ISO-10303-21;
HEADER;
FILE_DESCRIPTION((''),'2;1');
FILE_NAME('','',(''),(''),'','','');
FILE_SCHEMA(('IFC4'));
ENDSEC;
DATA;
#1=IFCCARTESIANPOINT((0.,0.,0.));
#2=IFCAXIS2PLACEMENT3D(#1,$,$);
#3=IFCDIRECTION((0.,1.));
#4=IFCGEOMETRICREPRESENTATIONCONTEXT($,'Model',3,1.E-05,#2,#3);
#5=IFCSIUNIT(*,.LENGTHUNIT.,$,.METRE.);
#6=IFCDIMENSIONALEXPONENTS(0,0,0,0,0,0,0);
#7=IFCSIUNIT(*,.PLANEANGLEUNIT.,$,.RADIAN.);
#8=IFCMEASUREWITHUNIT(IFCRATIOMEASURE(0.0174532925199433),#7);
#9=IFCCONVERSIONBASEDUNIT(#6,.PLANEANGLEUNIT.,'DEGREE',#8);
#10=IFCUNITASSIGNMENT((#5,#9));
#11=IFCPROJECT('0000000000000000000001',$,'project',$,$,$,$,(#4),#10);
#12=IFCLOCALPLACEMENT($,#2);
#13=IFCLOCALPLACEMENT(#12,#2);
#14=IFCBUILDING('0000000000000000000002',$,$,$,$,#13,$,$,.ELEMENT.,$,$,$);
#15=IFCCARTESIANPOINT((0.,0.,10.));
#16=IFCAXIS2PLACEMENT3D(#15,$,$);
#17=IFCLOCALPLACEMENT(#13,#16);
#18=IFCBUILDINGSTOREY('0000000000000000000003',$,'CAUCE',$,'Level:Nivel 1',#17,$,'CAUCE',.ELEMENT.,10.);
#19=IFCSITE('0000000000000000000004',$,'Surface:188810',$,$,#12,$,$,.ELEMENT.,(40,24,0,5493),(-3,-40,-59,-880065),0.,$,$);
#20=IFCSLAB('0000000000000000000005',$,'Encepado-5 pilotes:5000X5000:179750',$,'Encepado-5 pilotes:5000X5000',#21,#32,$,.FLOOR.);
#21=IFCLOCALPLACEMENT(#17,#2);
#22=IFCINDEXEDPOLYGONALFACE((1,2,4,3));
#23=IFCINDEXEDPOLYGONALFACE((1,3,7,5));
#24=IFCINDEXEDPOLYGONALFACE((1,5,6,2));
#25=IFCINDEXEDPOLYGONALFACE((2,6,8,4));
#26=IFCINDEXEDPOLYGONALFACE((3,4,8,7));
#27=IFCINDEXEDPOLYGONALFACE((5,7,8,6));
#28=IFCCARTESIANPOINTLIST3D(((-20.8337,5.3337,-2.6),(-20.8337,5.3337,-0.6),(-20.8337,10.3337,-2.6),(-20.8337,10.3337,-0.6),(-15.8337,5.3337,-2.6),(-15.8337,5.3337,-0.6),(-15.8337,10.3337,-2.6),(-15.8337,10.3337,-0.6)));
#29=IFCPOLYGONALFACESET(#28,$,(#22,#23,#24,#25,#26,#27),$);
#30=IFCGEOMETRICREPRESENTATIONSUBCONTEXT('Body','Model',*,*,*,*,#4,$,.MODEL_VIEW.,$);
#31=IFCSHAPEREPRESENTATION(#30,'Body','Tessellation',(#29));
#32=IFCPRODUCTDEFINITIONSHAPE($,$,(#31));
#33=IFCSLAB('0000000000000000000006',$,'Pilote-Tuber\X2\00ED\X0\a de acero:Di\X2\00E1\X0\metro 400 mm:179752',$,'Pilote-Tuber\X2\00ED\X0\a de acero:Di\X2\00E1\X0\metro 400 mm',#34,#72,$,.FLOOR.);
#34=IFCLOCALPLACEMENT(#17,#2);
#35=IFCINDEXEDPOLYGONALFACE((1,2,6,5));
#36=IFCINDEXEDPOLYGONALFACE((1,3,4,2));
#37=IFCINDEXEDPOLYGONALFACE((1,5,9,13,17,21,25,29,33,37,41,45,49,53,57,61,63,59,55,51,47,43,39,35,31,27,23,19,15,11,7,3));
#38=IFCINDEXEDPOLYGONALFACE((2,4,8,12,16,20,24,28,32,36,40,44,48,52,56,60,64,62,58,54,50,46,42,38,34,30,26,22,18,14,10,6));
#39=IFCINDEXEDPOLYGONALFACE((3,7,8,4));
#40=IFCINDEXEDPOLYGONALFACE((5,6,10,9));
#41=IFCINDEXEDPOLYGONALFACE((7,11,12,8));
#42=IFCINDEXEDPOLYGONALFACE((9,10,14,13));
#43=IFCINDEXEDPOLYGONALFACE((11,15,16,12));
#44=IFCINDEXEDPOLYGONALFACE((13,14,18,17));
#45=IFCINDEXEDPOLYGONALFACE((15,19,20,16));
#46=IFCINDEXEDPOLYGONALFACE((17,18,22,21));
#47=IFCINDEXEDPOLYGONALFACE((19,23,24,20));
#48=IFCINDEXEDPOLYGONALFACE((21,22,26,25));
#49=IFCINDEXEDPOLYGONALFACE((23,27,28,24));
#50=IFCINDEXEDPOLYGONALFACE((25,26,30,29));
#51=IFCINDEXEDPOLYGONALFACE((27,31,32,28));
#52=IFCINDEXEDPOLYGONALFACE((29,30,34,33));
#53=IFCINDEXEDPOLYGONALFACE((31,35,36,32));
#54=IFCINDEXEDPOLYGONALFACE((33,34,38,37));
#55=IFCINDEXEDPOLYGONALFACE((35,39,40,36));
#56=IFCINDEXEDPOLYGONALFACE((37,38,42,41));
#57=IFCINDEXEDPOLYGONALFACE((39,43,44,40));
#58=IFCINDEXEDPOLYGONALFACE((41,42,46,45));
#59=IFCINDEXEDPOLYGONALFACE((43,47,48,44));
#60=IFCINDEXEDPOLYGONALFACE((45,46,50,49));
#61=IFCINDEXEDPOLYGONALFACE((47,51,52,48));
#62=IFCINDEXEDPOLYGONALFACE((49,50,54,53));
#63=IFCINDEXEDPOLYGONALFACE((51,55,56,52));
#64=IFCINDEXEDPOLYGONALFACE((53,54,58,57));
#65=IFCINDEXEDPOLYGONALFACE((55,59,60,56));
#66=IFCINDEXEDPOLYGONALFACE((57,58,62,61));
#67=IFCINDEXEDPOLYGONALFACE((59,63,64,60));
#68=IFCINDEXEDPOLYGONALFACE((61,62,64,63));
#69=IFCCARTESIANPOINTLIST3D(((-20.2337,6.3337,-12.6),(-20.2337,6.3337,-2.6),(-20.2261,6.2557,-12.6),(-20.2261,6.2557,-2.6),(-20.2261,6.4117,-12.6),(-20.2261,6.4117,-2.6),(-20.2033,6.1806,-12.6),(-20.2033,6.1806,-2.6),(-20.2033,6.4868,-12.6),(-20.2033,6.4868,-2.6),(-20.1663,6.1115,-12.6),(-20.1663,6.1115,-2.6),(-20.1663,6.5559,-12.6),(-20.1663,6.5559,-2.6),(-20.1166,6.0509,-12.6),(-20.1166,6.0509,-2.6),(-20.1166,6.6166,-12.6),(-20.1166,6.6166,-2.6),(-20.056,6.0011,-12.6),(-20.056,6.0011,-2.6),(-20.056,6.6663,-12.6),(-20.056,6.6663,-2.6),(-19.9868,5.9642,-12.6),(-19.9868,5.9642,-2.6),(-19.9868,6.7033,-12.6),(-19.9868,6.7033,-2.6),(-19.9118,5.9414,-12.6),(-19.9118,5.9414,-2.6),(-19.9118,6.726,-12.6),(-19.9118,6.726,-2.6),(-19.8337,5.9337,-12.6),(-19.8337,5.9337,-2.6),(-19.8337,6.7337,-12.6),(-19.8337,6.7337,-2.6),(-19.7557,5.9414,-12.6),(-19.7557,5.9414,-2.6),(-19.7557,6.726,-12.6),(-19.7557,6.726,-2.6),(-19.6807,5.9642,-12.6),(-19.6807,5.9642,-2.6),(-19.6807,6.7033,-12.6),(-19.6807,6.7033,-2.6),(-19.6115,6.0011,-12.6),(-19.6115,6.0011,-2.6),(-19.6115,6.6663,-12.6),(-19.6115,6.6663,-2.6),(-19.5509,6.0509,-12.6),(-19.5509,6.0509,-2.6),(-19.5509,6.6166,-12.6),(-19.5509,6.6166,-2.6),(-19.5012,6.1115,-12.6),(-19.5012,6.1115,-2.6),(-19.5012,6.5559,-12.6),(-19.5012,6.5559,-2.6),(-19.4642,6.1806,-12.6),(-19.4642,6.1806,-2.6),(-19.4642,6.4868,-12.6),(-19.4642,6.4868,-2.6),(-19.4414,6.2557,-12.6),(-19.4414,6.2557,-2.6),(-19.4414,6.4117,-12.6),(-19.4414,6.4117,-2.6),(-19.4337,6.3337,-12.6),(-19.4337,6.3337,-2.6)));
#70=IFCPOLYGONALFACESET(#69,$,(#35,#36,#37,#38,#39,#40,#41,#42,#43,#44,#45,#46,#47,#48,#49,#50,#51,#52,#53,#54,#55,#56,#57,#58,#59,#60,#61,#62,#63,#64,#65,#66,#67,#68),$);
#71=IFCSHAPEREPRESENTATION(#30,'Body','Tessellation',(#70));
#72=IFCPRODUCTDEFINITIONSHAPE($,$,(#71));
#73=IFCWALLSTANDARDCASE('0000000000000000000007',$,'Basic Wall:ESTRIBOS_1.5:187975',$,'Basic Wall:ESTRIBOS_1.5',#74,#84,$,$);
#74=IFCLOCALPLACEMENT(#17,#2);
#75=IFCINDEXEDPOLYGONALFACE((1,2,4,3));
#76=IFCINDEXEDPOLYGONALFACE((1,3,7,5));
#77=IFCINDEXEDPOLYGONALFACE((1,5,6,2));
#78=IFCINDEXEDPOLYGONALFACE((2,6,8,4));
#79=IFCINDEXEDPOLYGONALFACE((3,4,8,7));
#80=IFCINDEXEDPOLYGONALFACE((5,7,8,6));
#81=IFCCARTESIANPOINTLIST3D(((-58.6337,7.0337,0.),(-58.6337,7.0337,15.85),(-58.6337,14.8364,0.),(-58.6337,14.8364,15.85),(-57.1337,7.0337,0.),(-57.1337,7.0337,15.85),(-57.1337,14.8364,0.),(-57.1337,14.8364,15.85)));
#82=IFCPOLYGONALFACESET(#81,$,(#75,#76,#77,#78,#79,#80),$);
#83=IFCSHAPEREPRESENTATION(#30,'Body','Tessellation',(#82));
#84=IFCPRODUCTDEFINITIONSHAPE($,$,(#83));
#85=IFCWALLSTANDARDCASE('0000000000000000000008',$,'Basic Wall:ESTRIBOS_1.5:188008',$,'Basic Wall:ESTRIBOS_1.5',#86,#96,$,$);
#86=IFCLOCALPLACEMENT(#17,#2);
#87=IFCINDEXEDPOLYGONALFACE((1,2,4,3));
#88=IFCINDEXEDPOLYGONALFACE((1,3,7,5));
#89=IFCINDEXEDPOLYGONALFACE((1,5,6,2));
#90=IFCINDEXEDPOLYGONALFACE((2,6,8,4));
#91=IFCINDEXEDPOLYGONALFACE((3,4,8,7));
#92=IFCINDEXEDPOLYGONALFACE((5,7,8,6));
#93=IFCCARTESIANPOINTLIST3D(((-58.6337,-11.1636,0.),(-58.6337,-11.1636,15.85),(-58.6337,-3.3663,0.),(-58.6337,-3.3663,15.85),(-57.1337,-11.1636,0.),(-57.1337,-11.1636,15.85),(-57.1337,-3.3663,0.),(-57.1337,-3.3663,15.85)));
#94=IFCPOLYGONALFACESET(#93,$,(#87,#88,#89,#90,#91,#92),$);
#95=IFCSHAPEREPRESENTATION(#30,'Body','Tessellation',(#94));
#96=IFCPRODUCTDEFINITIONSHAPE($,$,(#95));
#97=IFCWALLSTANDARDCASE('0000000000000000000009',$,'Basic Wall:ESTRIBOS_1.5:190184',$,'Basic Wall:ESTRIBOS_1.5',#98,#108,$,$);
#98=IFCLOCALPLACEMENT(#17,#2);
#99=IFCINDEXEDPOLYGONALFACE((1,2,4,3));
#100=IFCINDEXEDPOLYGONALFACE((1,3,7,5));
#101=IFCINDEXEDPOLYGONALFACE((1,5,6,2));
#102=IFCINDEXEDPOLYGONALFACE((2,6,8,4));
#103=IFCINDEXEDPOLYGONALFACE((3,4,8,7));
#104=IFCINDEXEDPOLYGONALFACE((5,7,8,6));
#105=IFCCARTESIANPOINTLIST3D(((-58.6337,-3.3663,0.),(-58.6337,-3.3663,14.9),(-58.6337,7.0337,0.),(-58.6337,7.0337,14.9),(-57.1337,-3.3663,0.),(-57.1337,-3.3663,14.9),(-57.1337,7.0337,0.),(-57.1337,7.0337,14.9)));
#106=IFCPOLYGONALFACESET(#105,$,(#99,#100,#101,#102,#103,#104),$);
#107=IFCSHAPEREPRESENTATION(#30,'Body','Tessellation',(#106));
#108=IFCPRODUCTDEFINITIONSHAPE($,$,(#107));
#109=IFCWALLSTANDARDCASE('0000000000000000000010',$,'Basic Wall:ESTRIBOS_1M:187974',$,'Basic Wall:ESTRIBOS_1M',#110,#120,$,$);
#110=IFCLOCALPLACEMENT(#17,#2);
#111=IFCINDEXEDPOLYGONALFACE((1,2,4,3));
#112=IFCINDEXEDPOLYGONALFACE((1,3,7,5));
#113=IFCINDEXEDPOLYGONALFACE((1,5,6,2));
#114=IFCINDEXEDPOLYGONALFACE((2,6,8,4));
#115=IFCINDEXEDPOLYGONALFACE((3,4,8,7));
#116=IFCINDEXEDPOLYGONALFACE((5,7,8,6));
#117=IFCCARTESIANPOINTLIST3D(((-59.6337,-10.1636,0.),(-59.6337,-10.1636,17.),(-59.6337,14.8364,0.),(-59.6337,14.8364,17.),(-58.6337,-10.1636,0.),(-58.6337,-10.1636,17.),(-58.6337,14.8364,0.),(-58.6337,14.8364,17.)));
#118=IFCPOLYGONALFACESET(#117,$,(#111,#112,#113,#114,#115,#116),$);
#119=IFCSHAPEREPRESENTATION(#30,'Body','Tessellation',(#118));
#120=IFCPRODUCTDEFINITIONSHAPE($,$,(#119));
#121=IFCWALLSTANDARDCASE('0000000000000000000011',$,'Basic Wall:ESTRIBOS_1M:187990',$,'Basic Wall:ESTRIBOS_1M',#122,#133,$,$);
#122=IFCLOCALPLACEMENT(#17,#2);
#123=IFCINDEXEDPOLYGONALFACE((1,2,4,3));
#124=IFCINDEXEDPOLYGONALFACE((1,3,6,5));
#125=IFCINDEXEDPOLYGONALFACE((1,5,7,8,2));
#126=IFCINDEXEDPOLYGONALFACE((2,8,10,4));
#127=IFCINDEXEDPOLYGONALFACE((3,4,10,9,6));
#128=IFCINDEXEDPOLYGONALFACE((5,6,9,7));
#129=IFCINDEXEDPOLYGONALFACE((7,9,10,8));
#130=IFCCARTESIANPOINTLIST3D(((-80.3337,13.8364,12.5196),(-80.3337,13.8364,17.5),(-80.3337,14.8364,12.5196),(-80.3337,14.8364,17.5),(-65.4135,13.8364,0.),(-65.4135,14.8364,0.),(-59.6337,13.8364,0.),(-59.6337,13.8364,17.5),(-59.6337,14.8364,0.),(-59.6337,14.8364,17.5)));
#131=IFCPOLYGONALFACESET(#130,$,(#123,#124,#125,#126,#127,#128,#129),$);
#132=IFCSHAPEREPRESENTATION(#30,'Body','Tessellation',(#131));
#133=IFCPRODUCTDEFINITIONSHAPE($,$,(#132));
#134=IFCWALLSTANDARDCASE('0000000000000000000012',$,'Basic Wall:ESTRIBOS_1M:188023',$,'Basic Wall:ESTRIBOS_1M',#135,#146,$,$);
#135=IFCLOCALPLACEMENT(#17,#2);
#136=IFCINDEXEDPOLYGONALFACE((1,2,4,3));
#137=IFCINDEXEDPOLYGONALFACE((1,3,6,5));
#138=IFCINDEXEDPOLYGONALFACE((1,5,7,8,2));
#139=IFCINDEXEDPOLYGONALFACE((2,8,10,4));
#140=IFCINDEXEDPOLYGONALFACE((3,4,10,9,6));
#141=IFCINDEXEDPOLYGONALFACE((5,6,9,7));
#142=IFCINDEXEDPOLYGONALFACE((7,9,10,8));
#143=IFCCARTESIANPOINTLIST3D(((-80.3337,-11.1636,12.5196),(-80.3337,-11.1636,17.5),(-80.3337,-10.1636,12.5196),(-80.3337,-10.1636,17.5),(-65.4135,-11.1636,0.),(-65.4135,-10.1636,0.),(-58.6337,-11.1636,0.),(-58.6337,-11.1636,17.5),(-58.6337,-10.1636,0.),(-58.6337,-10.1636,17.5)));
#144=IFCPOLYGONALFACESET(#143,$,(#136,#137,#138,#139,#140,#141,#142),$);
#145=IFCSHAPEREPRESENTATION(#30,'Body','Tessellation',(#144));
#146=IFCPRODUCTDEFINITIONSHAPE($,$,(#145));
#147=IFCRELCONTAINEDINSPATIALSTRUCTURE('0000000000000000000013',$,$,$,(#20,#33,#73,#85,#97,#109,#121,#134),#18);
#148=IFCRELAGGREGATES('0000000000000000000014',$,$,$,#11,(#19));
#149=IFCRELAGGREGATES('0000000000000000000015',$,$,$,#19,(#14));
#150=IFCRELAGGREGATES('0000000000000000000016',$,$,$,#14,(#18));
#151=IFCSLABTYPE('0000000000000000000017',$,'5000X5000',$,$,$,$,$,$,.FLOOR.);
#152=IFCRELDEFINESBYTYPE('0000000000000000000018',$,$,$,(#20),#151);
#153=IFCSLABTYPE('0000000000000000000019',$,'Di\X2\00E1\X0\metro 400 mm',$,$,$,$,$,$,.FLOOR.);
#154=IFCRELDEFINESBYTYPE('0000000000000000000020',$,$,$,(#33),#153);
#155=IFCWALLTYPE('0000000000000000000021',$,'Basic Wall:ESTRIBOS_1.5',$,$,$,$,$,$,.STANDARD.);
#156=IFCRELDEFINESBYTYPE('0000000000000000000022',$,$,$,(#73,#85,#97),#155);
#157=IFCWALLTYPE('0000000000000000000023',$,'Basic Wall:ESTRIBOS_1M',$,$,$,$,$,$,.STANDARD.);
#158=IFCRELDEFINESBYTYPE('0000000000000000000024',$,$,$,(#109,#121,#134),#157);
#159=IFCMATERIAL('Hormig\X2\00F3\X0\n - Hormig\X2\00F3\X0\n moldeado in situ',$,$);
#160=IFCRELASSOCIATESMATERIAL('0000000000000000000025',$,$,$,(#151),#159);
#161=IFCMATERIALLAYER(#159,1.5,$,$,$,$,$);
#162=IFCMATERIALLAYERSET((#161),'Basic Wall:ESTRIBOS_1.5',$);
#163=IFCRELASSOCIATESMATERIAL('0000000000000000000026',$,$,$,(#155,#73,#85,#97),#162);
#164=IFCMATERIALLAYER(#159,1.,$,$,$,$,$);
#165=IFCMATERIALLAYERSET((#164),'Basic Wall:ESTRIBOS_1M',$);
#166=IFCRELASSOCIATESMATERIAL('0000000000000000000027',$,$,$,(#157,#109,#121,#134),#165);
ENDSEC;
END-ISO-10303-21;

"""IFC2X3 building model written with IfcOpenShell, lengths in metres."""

from ifc_helpers import new_model, entity, si_unit, converted_unit, direction, frame, frame_2d, origin, origin_2d_with_axis, place, context, subcontext, project, spatial, rectangle, circle, extrude, clip, halfspace, material, layer, layer_set, layer_usage, type_object, element, save


model = new_model("IFC2X3")

# Units and contexts
model_context = context("Model", 3, precision=1e-05, world=origin(), true_north=direction((0.0, 1.0)))
body_context = subcontext(model_context, "Body", "Model", "MODEL_VIEW")
ifc_project = project(units=[si_unit("LENGTHUNIT", "METRE"), converted_unit("PLANEANGLEUNIT", "DEGREE", entity("IfcRatioMeasure", 0.0174532925199433), si_unit("PLANEANGLEUNIT", "RADIAN"), dimensions=[0, 0, 0, 0, 0, 0, 0])], contexts=[model_context])

# Site, building, storey
site_placement = place(None, origin())
site = spatial("IfcSite", under=ifc_project, at=site_placement, Name="Surface:188810", CompositionType="ELEMENT", RefLatitude=(40, 24, 0, 5493), RefLongitude=(-3, -40, -59, -880065), RefElevation=0.0)
building_placement = place(site_placement, origin())
building = spatial("IfcBuilding", under=site, at=building_placement, CompositionType="ELEMENT")
storey_placement = place(building_placement, frame((0.0, 0.0, 10.0)))
storey = spatial("IfcBuildingStorey", under=building, at=storey_placement, Name="CAUCE", ObjectType="Level:Nivel 1", LongName="CAUCE", CompositionType="ELEMENT", Elevation=10.0)

# Shared definitions
ifc_material_1 = material(Name="Hormigón - Hormigón moldeado in situ")

# Slabs
slab_type_1 = type_object("IfcSlabType", Name="5000X5000", PredefinedType="FLOOR", material=ifc_material_1)
slab_1_placement = place(storey_placement, origin())
element("IfcSlab", 1, at=slab_1_placement, inside=storey, type_object=slab_type_1, Name="Encepado-5 pilotes:5000X5000:179750", ObjectType="Encepado-5 pilotes:5000X5000", PredefinedType="FLOOR", context=body_context, shape_type="SweptSolid", body=[
    extrude(rectangle(XDim=5.0, YDim=5.0, at=origin_2d_with_axis()), frame((-18.3337, 7.8337, -2.6), z_axis=(0.0, 0.0, 1.0), x_axis=(-1.0, 0.0, 0.0)), (0.0, 0.0, 1.0), 2.0),
])
slab_type_2 = type_object("IfcSlabType", Name="Diámetro 400 mm", PredefinedType="FLOOR")
slab_2_placement = place(storey_placement, origin())
element("IfcSlab", 2, at=slab_2_placement, inside=storey, type_object=slab_type_2, Name="Pilote-Tubería de acero:Diámetro 400 mm:179752", ObjectType="Pilote-Tubería de acero:Diámetro 400 mm", PredefinedType="FLOOR", context=body_context, shape_type="SweptSolid", body=[
    extrude(circle(Radius=0.4, at=origin_2d_with_axis()), frame((-19.8337, 6.3337, -12.6)), (0.0, 0.0, 1.0), 10.0),
])

# Walls
ifc_layer_1 = layer(ifc_material_1, 1.5)
ifc_layer_set_1 = layer_set([ifc_layer_1], Name="Basic Wall:ESTRIBOS_1.5")
ifc_layer_usage_1 = layer_usage(ifc_layer_set_1, "AXIS2", "POSITIVE", -0.75)
wall_type_1 = type_object("IfcWallType", Name="Basic Wall:ESTRIBOS_1.5", PredefinedType="STANDARD", material=ifc_layer_set_1)
wall_1_placement = place(storey_placement, frame((-57.8837, 14.8364, 0.0), z_axis=(0.0, 0.0, 1.0), x_axis=(0.0, -1.0, 0.0)))
element("IfcWallStandardCase", 3, at=wall_1_placement, inside=storey, type_object=wall_type_1, material=ifc_layer_usage_1, Name="Basic Wall:ESTRIBOS_1.5:187975", ObjectType="Basic Wall:ESTRIBOS_1.5", context=body_context, shape_type="SweptSolid", body=[
    extrude(rectangle(XDim=7.8027, YDim=1.5, at=frame_2d((3.9014, 0.0), x_axis=(-1.0, 0.0))), origin(), (0.0, 0.0, 1.0), 15.85),
])
ifc_layer_usage_2 = layer_usage(ifc_layer_set_1, "AXIS2", "NEGATIVE", 0.75)
wall_2_placement = place(storey_placement, frame((-57.8837, -11.1636, 0.0), z_axis=(0.0, 0.0, 1.0), x_axis=(0.0, 1.0, 0.0)))
element("IfcWallStandardCase", 4, at=wall_2_placement, inside=storey, type_object=wall_type_1, material=ifc_layer_usage_2, Name="Basic Wall:ESTRIBOS_1.5:188008", ObjectType="Basic Wall:ESTRIBOS_1.5", context=body_context, shape_type="SweptSolid", body=[
    extrude(rectangle(XDim=7.7973, YDim=1.5, at=frame_2d((3.8986, 0.0), x_axis=(-1.0, 0.0))), origin(), (0.0, 0.0, 1.0), 15.85),
])
ifc_layer_usage_3 = layer_usage(ifc_layer_set_1, "AXIS2", "POSITIVE", -0.75)
wall_3_placement = place(storey_placement, frame((-57.8837, 7.0337, 0.0), z_axis=(0.0, 0.0, 1.0), x_axis=(0.0, -1.0, 0.0)))
element("IfcWallStandardCase", 5, at=wall_3_placement, inside=storey, type_object=wall_type_1, material=ifc_layer_usage_3, Name="Basic Wall:ESTRIBOS_1.5:190184", ObjectType="Basic Wall:ESTRIBOS_1.5", context=body_context, shape_type="SweptSolid", body=[
    extrude(rectangle(XDim=10.4, YDim=1.5, at=frame_2d((5.2, 0.0), x_axis=(-1.0, 0.0))), origin(), (0.0, 0.0, 1.0), 14.9),
])
ifc_layer_2 = layer(ifc_material_1, 1.0)
ifc_layer_set_2 = layer_set([ifc_layer_2], Name="Basic Wall:ESTRIBOS_1M")
ifc_layer_usage_4 = layer_usage(ifc_layer_set_2, "AXIS2", "NEGATIVE", 0.5)
wall_type_2 = type_object("IfcWallType", Name="Basic Wall:ESTRIBOS_1M", PredefinedType="STANDARD", material=ifc_layer_set_2)
wall_4_placement = place(storey_placement, frame((-59.1337, 14.8364, 0.0), z_axis=(0.0, 0.0, 1.0), x_axis=(0.0, -1.0, 0.0)))
element("IfcWallStandardCase", 6, at=wall_4_placement, inside=storey, type_object=wall_type_2, material=ifc_layer_usage_4, Name="Basic Wall:ESTRIBOS_1M:187974", ObjectType="Basic Wall:ESTRIBOS_1M", context=body_context, shape_type="SweptSolid", body=[
    extrude(rectangle(XDim=25.0, YDim=1.0, at=frame_2d((12.5, 0.0), x_axis=(-1.0, 0.0))), origin(), (0.0, 0.0, 1.0), 17.0),
])
ifc_layer_usage_5 = layer_usage(ifc_layer_set_2, "AXIS2", "POSITIVE", -0.5)
wall_5_placement = place(storey_placement, frame((-59.6337, 14.3364, 0.0), z_axis=(0.0, 0.0, 1.0), x_axis=(-1.0, 0.0, 0.0)))
element("IfcWallStandardCase", 7, at=wall_5_placement, inside=storey, type_object=wall_type_2, material=ifc_layer_usage_5, Name="Basic Wall:ESTRIBOS_1M:187990", ObjectType="Basic Wall:ESTRIBOS_1M", context=body_context, shape_type="Clipping", body=[
    clip(extrude(rectangle(XDim=20.7, YDim=1.0, at=frame_2d((10.35, 0.0), x_axis=(-1.0, 0.0))), origin(), (0.0, 0.0, 1.0), 17.5), halfspace(frame((20.7, -0.5, 12.5196), z_axis=(0.642788, 0.0, -0.766044), x_axis=(0.0, 1.0, 0.0)), False)),
])
ifc_layer_usage_6 = layer_usage(ifc_layer_set_2, "AXIS2", "NEGATIVE", 0.5)
wall_6_placement = place(storey_placement, frame((-58.6337, -10.6636, 0.0), z_axis=(0.0, 0.0, 1.0), x_axis=(-1.0, 0.0, 0.0)))
element("IfcWallStandardCase", 8, at=wall_6_placement, inside=storey, type_object=wall_type_2, material=ifc_layer_usage_6, Name="Basic Wall:ESTRIBOS_1M:188023", ObjectType="Basic Wall:ESTRIBOS_1M", context=body_context, shape_type="Clipping", body=[
    clip(extrude(rectangle(XDim=21.7, YDim=1.0, at=frame_2d((10.85, 0.0), x_axis=(-1.0, 0.0))), origin(), (0.0, 0.0, 1.0), 17.5), halfspace(frame((21.7, -0.5, 12.5196), z_axis=(0.642788, 0.0, -0.766044), x_axis=(0.0, 1.0, 0.0)), False)),
])

save(model, "model.ifc")
